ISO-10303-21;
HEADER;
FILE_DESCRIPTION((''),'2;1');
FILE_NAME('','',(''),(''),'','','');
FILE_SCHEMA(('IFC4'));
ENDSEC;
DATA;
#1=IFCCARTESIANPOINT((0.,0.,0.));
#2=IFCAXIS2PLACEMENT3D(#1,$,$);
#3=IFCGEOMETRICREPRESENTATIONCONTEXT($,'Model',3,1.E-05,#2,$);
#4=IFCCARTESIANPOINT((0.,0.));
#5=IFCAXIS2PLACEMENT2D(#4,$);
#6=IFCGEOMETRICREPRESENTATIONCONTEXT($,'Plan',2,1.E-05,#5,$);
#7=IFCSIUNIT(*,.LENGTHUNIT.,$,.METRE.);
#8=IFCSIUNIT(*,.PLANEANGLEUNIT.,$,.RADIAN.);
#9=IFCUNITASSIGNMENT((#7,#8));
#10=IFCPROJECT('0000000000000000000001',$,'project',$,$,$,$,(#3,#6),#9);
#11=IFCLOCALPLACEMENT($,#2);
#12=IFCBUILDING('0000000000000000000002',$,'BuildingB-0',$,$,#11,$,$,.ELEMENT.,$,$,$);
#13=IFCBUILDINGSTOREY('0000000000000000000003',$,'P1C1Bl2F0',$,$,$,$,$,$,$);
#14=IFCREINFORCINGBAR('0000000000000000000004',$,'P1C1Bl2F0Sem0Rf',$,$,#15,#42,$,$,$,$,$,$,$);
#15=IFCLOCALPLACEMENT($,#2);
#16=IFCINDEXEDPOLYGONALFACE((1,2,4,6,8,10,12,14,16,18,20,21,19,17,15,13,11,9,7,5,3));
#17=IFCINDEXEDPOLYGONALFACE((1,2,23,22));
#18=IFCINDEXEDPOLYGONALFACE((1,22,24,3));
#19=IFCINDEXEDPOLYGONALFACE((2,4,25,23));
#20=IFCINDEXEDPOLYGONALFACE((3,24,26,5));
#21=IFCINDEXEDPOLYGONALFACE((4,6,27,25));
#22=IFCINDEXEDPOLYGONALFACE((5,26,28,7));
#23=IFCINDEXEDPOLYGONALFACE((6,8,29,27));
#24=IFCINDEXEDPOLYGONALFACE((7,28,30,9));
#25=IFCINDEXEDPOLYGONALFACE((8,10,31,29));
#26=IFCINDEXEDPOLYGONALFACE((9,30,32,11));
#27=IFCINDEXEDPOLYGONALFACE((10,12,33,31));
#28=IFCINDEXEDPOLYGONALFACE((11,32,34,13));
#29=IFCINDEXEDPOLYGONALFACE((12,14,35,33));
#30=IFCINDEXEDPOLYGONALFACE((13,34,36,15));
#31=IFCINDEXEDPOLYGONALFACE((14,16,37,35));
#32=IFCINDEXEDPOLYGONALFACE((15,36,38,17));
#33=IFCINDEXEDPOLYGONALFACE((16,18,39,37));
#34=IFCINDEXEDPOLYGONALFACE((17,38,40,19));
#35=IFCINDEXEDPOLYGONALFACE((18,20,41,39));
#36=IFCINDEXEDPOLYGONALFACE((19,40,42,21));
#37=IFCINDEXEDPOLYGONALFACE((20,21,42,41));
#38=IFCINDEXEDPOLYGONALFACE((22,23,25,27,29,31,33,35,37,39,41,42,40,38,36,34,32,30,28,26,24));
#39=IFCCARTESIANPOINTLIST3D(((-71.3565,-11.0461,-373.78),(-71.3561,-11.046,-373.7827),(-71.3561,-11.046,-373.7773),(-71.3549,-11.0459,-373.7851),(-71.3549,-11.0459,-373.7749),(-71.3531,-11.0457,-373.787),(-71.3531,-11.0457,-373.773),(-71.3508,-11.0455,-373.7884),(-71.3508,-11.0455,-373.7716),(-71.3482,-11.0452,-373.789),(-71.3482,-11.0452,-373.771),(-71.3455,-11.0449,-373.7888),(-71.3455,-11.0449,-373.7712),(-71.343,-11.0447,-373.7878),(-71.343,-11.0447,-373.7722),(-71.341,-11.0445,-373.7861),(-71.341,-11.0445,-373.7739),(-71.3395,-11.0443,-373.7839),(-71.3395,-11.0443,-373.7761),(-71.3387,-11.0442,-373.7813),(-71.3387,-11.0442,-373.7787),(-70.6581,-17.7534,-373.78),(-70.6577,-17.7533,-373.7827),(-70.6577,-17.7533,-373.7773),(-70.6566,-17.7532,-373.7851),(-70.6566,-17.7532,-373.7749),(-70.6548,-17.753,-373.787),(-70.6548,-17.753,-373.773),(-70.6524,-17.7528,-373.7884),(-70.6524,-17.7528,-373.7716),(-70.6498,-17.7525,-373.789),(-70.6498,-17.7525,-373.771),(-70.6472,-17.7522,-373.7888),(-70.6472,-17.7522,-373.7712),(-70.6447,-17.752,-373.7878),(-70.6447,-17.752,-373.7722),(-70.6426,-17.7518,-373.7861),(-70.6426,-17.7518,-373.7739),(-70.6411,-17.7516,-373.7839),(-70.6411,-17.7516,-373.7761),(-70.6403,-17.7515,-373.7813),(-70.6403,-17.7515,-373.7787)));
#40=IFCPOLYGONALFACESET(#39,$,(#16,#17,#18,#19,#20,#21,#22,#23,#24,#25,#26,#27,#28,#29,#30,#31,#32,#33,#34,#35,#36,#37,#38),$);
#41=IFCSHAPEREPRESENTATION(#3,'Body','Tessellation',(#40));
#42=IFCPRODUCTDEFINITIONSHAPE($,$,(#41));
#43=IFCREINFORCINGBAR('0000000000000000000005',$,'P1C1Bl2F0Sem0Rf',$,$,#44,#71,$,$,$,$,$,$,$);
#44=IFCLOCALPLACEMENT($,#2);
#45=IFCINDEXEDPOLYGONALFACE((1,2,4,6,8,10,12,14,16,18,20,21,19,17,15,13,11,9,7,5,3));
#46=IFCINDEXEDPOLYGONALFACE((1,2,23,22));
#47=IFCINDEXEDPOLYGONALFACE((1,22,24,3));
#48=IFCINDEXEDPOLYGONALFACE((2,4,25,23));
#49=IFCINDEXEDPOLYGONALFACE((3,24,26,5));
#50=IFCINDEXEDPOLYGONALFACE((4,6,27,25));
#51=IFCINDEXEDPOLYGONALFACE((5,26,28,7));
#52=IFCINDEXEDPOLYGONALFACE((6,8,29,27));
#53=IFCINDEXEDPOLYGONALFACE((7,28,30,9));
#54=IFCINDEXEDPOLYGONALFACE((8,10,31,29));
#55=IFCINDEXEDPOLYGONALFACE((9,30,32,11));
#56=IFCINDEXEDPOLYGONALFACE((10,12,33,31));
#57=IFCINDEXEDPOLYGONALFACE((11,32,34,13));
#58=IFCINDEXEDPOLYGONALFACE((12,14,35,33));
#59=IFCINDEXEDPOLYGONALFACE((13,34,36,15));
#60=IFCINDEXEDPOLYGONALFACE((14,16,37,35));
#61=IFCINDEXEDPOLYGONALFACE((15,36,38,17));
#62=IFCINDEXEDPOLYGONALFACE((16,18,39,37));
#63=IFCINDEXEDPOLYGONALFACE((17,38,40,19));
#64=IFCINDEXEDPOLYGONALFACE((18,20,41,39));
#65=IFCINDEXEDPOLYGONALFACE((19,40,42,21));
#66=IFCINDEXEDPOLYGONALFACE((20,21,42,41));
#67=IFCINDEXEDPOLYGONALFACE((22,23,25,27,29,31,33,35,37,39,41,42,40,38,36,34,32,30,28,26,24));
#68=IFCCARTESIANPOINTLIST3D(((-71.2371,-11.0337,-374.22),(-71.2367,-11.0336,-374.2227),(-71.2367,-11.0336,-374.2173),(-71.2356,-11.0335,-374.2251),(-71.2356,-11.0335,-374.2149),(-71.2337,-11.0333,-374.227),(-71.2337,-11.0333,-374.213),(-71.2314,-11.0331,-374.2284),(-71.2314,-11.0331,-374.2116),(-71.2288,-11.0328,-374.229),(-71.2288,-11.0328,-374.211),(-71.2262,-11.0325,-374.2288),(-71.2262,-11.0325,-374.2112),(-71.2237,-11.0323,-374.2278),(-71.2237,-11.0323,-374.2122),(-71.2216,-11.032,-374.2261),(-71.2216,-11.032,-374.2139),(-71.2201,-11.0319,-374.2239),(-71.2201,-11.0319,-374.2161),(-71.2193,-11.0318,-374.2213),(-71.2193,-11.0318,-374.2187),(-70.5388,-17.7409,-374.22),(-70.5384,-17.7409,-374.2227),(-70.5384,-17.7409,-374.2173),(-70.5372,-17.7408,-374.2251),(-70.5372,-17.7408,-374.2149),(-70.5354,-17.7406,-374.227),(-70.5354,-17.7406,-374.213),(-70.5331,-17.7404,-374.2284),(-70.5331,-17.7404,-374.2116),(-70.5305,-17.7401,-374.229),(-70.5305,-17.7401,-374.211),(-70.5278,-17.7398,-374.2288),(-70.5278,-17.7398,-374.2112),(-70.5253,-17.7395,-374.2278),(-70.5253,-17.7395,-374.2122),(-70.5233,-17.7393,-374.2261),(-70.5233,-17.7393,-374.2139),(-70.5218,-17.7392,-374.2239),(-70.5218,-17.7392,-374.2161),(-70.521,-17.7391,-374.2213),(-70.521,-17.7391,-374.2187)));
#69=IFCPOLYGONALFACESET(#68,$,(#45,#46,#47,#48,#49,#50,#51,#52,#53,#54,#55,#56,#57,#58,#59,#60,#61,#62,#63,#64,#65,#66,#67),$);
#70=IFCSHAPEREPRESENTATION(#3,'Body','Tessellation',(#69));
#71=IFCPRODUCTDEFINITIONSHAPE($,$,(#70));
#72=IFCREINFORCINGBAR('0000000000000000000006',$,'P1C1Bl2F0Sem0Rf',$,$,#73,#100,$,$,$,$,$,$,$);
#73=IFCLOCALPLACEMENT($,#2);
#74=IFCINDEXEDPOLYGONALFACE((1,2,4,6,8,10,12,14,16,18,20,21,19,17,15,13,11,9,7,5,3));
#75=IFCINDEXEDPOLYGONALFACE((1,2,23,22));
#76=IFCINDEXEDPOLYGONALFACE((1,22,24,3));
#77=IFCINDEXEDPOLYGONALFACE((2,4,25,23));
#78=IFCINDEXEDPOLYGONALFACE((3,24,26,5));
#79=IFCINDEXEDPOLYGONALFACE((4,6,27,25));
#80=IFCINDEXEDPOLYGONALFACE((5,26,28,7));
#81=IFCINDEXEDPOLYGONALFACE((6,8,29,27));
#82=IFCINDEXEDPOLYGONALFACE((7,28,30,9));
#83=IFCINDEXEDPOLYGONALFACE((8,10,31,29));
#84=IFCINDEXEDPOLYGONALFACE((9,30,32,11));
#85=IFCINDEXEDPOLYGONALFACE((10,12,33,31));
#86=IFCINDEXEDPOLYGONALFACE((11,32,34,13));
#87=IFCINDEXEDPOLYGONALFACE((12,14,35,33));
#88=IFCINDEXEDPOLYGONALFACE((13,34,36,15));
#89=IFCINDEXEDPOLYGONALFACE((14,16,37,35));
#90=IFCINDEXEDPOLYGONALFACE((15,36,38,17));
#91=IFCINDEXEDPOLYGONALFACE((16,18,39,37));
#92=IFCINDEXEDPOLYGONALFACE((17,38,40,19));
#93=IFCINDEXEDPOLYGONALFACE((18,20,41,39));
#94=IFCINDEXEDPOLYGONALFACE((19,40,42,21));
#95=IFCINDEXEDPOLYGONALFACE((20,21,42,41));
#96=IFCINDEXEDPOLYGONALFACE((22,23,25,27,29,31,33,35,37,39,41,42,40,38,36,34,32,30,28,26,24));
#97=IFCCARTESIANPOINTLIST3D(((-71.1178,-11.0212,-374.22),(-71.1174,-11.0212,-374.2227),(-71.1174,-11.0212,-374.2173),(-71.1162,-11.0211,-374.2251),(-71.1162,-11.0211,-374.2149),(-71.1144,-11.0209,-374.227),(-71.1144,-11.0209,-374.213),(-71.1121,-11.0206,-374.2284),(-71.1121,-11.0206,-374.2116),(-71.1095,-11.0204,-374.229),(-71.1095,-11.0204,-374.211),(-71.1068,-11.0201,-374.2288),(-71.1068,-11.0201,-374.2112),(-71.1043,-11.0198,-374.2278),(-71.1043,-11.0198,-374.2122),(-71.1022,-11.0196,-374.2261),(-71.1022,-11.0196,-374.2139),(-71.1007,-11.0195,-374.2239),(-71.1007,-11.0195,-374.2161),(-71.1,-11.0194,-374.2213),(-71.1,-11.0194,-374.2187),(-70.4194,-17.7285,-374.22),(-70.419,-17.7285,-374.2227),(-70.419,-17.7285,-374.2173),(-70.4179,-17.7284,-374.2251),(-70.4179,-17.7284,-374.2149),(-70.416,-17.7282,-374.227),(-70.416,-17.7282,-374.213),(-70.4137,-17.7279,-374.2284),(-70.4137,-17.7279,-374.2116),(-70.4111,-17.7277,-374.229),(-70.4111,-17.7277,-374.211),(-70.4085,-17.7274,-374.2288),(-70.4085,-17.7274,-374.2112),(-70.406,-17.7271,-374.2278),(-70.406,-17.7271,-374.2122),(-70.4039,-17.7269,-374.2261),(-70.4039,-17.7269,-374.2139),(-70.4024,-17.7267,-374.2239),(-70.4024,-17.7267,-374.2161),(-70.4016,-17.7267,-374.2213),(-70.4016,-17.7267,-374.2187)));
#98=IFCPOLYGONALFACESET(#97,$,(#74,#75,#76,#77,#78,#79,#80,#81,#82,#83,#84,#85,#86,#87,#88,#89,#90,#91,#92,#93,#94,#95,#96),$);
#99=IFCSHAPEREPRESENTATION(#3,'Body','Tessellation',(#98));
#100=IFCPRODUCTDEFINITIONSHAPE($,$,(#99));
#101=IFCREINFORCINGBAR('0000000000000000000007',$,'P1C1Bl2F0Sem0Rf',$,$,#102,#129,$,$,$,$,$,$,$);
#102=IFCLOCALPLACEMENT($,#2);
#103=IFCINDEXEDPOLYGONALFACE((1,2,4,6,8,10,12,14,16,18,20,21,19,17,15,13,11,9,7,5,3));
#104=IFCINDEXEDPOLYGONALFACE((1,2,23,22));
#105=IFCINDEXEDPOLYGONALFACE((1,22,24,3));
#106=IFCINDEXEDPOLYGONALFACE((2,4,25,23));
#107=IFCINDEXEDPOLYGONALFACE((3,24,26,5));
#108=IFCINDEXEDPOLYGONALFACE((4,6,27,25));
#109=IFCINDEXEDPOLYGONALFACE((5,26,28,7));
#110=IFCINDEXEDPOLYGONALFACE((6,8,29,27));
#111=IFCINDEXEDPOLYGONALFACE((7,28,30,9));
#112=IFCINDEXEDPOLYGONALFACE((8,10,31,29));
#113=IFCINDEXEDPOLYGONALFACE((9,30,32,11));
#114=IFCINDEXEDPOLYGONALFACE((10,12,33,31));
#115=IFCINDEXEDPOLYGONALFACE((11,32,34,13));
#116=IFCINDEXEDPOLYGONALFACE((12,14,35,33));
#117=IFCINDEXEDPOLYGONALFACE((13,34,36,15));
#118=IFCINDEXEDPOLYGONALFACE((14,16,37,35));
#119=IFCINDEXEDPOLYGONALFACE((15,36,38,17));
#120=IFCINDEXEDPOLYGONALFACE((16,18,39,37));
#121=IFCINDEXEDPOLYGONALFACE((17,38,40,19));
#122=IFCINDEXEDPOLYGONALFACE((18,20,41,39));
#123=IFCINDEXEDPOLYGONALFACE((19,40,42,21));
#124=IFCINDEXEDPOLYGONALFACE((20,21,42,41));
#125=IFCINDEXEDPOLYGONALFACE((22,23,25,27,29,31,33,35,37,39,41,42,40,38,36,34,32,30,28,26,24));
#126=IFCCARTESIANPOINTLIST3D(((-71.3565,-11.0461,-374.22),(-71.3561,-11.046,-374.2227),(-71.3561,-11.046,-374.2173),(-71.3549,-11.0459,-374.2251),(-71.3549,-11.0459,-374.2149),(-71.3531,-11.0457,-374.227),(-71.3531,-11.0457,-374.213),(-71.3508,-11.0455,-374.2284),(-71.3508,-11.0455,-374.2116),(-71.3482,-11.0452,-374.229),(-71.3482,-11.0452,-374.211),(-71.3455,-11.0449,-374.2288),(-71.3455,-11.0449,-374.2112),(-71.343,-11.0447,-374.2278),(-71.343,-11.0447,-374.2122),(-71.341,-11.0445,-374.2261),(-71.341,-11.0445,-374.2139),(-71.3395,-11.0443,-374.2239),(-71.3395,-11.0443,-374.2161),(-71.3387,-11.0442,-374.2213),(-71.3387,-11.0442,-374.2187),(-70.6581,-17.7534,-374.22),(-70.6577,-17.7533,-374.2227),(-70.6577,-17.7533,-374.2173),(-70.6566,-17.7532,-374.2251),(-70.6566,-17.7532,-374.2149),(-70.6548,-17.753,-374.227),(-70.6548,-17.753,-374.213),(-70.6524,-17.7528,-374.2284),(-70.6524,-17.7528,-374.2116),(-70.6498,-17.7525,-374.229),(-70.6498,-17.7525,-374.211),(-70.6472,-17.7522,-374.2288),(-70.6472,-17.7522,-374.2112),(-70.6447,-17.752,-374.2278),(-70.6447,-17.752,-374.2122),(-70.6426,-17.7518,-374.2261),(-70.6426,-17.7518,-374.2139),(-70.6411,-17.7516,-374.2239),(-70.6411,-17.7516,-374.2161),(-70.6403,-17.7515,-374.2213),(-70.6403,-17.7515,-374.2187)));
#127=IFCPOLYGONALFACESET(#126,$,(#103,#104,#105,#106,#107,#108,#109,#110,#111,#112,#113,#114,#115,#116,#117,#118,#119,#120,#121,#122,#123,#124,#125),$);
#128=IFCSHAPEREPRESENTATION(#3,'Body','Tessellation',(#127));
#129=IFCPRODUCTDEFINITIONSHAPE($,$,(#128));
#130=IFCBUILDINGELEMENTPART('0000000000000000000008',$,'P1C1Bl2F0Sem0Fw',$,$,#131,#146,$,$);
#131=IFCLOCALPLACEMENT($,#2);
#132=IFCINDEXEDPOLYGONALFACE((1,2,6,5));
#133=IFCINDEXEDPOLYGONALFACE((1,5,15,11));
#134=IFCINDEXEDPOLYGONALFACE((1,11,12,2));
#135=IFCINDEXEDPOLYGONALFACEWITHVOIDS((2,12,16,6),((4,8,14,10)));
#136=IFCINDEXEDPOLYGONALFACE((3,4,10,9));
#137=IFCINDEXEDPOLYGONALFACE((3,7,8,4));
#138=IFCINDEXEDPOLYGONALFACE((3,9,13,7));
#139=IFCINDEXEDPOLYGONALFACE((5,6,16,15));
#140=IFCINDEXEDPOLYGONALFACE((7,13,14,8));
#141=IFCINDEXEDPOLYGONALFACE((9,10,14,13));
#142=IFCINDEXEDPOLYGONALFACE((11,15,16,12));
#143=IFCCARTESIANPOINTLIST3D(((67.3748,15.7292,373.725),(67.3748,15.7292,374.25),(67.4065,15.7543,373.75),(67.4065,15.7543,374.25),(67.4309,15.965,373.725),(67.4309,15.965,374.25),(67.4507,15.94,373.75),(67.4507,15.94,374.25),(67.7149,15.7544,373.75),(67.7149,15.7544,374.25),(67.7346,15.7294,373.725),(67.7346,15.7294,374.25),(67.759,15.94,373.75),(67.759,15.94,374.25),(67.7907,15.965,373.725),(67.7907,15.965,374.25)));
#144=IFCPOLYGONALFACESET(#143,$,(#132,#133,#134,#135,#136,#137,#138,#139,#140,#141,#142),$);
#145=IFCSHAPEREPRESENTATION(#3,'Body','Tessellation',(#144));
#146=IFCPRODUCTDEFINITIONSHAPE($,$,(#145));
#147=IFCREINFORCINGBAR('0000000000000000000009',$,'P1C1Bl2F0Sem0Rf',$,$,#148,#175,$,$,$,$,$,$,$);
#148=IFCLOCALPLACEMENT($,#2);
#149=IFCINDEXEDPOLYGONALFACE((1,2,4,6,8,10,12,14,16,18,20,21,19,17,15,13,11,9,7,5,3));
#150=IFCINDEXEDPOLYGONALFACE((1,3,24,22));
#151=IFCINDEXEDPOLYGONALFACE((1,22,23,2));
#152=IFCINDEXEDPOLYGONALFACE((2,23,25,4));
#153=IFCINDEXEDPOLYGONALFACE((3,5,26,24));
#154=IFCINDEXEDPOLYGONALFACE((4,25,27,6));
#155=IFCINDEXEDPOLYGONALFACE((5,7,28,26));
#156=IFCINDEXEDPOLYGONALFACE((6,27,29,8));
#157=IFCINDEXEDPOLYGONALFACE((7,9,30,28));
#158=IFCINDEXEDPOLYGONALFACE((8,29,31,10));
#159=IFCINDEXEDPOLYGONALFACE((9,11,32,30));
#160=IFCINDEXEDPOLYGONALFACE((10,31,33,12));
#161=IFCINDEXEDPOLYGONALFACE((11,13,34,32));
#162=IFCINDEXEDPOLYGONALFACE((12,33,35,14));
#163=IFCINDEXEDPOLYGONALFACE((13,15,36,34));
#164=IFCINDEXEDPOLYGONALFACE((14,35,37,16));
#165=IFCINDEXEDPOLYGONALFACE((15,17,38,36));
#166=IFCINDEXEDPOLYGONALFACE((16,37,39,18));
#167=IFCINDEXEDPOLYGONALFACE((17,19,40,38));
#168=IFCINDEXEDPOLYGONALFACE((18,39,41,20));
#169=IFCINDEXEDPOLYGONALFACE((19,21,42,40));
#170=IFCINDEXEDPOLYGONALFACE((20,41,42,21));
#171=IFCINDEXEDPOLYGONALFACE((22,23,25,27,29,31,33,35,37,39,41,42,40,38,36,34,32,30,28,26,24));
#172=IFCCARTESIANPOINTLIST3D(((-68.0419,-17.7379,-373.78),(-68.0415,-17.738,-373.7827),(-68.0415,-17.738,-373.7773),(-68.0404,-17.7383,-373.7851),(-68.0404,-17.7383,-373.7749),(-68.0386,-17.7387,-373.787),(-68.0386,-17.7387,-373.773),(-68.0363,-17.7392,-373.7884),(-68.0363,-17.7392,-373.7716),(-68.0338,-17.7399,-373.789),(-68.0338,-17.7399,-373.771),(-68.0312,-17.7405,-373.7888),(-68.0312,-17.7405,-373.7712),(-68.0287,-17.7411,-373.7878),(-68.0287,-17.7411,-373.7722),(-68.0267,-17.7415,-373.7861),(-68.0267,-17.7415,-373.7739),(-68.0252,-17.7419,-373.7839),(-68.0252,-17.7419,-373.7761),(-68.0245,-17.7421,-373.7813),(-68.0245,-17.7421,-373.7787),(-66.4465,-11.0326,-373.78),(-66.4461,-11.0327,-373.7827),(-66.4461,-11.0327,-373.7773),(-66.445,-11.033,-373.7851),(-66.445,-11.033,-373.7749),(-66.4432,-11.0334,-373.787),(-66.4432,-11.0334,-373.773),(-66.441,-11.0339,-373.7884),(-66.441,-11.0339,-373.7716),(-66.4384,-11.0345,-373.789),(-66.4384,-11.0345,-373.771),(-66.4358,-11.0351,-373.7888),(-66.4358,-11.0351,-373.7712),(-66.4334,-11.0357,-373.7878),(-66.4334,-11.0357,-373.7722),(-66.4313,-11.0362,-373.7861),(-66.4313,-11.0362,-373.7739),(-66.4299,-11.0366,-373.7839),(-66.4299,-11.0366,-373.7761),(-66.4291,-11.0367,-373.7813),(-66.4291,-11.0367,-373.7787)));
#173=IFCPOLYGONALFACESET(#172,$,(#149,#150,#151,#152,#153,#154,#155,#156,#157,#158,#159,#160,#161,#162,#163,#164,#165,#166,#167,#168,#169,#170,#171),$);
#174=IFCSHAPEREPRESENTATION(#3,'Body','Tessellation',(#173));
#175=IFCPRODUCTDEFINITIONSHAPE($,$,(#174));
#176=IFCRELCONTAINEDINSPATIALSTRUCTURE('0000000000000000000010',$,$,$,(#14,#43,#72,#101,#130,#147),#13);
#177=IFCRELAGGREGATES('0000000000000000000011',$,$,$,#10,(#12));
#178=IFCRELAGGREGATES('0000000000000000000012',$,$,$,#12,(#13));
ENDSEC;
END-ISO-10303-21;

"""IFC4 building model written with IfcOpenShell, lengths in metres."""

from ifc_helpers import new_model, entity, si_unit, origin, origin_2d, place, context, project, spatial, polyline, outline, extrude, element, save


model = new_model("IFC4")

# Units and contexts
model_context = context("Model", 3, precision=1e-05, world=origin())
plan_context = context("Plan", 2, precision=1e-05, world=origin_2d())
ifc_project = project(units=[si_unit("LENGTHUNIT", "METRE"), si_unit("PLANEANGLEUNIT", "RADIAN")], contexts=[model_context, plan_context])

# Building, storey
building_placement = place(None, origin())
building = spatial("IfcBuilding", under=ifc_project, at=building_placement, Name="BuildingB-0", CompositionType="ELEMENT")
storey = spatial("IfcBuildingStorey", under=building, Name="P1C1Bl2F0")

# Reinforcing bars
element("IfcReinforcingBar", 1, inside=storey, Name="P1C1Bl2F0Sem0Rf", context=model_context, shape_type="SweptSolid", body=[
    entity("IfcSurfaceCurveSweptAreaSolid", entity("IfcCircleProfileDef", "AREA", None, None, 0.009), None, entity("IfcPolyline", [entity("IfcCartesianPoint", [70.6492, 17.7524, 373.78]), entity("IfcCartesianPoint", [71.3475, 11.0452, 373.78])]), None, None, entity("IfcPlane", entity("IfcAxis2Placement3D", entity("IfcCartesianPoint", [70.6492, 17.7524, 373.78]), entity("IfcDirection", [0.0, 0.0, 1.0]), entity("IfcDirection", [1.0, 0.0, 0.0])))),
])
element("IfcReinforcingBar", 2, inside=storey, Name="P1C1Bl2F0Sem0Rf", context=model_context, shape_type="SweptSolid", body=[
    entity("IfcSurfaceCurveSweptAreaSolid", entity("IfcCircleProfileDef", "AREA", None, None, 0.009), None, entity("IfcPolyline", [entity("IfcCartesianPoint", [70.5298, 17.74, 374.22]), entity("IfcCartesianPoint", [71.2282, 11.0327, 374.22])]), None, None, entity("IfcPlane", entity("IfcAxis2Placement3D", entity("IfcCartesianPoint", [70.5298, 17.74, 374.22]), entity("IfcDirection", [0.0, 0.0, 1.0]), entity("IfcDirection", [1.0, 0.0, 0.0])))),
])
element("IfcReinforcingBar", 3, inside=storey, Name="P1C1Bl2F0Sem0Rf", context=model_context, shape_type="SweptSolid", body=[
    entity("IfcSurfaceCurveSweptAreaSolid", entity("IfcCircleProfileDef", "AREA", None, None, 0.009), None, entity("IfcPolyline", [entity("IfcCartesianPoint", [70.4105, 17.7276, 374.22]), entity("IfcCartesianPoint", [71.1088, 11.0203, 374.22])]), None, None, entity("IfcPlane", entity("IfcAxis2Placement3D", entity("IfcCartesianPoint", [70.4105, 17.7276, 374.22]), entity("IfcDirection", [0.0, 0.0, 1.0]), entity("IfcDirection", [1.0, 0.0, 0.0])))),
])
element("IfcReinforcingBar", 4, inside=storey, Name="P1C1Bl2F0Sem0Rf", context=model_context, shape_type="SweptSolid", body=[
    entity("IfcSurfaceCurveSweptAreaSolid", entity("IfcCircleProfileDef", "AREA", None, None, 0.009), None, entity("IfcPolyline", [entity("IfcCartesianPoint", [70.6492, 17.7524, 374.22]), entity("IfcCartesianPoint", [71.3475, 11.0452, 374.22])]), None, None, entity("IfcPlane", entity("IfcAxis2Placement3D", entity("IfcCartesianPoint", [70.6492, 17.7524, 374.22]), entity("IfcDirection", [0.0, 0.0, 1.0]), entity("IfcDirection", [1.0, 0.0, 0.0])))),
])

# Building element part, opening
building_element_part_1 = element("IfcBuildingElementPart", 5, inside=storey, Name="P1C1Bl2F0Sem0Fw", context=model_context, shape_type="SweptSolid", body=[
    extrude(outline(polyline([(67.7346, 15.7294, 373.725), (67.7907, 15.965, 373.725), (67.4309, 15.965, 373.725), (67.3748, 15.7292, 373.725), (67.7346, 15.7294, 373.725)])), None, (0.0, 0.0, 1.0), 0.525),
])
element("IfcOpeningElement", 6, inside=storey, cuts=building_element_part_1, context=model_context, shape_type="SweptSolid", body=[
    extrude(outline(polyline([(67.7149, 15.7544, 373.75), (67.759, 15.94, 373.75), (67.4507, 15.94, 373.75), (67.4065, 15.7543, 373.75), (67.7149, 15.7544, 373.75)])), None, (0.0, 0.0, 1.0), 0.5),
])

# Reinforcing bar
element("IfcReinforcingBar", 7, inside=storey, Name="P1C1Bl2F0Sem0Rf", context=model_context, shape_type="SweptSolid", body=[
    entity("IfcSurfaceCurveSweptAreaSolid", entity("IfcCircleProfileDef", "AREA", None, None, 0.009), None, entity("IfcPolyline", [entity("IfcCartesianPoint", [68.0331, 17.74, 373.78]), entity("IfcCartesianPoint", [66.4378, 11.0347, 373.78])]), None, None, entity("IfcPlane", entity("IfcAxis2Placement3D", entity("IfcCartesianPoint", [68.0331, 17.74, 373.78]), entity("IfcDirection", [0.0, 0.0, 1.0]), entity("IfcDirection", [1.0, 0.0, 0.0])))),
])

save(model, "model.ifc")
